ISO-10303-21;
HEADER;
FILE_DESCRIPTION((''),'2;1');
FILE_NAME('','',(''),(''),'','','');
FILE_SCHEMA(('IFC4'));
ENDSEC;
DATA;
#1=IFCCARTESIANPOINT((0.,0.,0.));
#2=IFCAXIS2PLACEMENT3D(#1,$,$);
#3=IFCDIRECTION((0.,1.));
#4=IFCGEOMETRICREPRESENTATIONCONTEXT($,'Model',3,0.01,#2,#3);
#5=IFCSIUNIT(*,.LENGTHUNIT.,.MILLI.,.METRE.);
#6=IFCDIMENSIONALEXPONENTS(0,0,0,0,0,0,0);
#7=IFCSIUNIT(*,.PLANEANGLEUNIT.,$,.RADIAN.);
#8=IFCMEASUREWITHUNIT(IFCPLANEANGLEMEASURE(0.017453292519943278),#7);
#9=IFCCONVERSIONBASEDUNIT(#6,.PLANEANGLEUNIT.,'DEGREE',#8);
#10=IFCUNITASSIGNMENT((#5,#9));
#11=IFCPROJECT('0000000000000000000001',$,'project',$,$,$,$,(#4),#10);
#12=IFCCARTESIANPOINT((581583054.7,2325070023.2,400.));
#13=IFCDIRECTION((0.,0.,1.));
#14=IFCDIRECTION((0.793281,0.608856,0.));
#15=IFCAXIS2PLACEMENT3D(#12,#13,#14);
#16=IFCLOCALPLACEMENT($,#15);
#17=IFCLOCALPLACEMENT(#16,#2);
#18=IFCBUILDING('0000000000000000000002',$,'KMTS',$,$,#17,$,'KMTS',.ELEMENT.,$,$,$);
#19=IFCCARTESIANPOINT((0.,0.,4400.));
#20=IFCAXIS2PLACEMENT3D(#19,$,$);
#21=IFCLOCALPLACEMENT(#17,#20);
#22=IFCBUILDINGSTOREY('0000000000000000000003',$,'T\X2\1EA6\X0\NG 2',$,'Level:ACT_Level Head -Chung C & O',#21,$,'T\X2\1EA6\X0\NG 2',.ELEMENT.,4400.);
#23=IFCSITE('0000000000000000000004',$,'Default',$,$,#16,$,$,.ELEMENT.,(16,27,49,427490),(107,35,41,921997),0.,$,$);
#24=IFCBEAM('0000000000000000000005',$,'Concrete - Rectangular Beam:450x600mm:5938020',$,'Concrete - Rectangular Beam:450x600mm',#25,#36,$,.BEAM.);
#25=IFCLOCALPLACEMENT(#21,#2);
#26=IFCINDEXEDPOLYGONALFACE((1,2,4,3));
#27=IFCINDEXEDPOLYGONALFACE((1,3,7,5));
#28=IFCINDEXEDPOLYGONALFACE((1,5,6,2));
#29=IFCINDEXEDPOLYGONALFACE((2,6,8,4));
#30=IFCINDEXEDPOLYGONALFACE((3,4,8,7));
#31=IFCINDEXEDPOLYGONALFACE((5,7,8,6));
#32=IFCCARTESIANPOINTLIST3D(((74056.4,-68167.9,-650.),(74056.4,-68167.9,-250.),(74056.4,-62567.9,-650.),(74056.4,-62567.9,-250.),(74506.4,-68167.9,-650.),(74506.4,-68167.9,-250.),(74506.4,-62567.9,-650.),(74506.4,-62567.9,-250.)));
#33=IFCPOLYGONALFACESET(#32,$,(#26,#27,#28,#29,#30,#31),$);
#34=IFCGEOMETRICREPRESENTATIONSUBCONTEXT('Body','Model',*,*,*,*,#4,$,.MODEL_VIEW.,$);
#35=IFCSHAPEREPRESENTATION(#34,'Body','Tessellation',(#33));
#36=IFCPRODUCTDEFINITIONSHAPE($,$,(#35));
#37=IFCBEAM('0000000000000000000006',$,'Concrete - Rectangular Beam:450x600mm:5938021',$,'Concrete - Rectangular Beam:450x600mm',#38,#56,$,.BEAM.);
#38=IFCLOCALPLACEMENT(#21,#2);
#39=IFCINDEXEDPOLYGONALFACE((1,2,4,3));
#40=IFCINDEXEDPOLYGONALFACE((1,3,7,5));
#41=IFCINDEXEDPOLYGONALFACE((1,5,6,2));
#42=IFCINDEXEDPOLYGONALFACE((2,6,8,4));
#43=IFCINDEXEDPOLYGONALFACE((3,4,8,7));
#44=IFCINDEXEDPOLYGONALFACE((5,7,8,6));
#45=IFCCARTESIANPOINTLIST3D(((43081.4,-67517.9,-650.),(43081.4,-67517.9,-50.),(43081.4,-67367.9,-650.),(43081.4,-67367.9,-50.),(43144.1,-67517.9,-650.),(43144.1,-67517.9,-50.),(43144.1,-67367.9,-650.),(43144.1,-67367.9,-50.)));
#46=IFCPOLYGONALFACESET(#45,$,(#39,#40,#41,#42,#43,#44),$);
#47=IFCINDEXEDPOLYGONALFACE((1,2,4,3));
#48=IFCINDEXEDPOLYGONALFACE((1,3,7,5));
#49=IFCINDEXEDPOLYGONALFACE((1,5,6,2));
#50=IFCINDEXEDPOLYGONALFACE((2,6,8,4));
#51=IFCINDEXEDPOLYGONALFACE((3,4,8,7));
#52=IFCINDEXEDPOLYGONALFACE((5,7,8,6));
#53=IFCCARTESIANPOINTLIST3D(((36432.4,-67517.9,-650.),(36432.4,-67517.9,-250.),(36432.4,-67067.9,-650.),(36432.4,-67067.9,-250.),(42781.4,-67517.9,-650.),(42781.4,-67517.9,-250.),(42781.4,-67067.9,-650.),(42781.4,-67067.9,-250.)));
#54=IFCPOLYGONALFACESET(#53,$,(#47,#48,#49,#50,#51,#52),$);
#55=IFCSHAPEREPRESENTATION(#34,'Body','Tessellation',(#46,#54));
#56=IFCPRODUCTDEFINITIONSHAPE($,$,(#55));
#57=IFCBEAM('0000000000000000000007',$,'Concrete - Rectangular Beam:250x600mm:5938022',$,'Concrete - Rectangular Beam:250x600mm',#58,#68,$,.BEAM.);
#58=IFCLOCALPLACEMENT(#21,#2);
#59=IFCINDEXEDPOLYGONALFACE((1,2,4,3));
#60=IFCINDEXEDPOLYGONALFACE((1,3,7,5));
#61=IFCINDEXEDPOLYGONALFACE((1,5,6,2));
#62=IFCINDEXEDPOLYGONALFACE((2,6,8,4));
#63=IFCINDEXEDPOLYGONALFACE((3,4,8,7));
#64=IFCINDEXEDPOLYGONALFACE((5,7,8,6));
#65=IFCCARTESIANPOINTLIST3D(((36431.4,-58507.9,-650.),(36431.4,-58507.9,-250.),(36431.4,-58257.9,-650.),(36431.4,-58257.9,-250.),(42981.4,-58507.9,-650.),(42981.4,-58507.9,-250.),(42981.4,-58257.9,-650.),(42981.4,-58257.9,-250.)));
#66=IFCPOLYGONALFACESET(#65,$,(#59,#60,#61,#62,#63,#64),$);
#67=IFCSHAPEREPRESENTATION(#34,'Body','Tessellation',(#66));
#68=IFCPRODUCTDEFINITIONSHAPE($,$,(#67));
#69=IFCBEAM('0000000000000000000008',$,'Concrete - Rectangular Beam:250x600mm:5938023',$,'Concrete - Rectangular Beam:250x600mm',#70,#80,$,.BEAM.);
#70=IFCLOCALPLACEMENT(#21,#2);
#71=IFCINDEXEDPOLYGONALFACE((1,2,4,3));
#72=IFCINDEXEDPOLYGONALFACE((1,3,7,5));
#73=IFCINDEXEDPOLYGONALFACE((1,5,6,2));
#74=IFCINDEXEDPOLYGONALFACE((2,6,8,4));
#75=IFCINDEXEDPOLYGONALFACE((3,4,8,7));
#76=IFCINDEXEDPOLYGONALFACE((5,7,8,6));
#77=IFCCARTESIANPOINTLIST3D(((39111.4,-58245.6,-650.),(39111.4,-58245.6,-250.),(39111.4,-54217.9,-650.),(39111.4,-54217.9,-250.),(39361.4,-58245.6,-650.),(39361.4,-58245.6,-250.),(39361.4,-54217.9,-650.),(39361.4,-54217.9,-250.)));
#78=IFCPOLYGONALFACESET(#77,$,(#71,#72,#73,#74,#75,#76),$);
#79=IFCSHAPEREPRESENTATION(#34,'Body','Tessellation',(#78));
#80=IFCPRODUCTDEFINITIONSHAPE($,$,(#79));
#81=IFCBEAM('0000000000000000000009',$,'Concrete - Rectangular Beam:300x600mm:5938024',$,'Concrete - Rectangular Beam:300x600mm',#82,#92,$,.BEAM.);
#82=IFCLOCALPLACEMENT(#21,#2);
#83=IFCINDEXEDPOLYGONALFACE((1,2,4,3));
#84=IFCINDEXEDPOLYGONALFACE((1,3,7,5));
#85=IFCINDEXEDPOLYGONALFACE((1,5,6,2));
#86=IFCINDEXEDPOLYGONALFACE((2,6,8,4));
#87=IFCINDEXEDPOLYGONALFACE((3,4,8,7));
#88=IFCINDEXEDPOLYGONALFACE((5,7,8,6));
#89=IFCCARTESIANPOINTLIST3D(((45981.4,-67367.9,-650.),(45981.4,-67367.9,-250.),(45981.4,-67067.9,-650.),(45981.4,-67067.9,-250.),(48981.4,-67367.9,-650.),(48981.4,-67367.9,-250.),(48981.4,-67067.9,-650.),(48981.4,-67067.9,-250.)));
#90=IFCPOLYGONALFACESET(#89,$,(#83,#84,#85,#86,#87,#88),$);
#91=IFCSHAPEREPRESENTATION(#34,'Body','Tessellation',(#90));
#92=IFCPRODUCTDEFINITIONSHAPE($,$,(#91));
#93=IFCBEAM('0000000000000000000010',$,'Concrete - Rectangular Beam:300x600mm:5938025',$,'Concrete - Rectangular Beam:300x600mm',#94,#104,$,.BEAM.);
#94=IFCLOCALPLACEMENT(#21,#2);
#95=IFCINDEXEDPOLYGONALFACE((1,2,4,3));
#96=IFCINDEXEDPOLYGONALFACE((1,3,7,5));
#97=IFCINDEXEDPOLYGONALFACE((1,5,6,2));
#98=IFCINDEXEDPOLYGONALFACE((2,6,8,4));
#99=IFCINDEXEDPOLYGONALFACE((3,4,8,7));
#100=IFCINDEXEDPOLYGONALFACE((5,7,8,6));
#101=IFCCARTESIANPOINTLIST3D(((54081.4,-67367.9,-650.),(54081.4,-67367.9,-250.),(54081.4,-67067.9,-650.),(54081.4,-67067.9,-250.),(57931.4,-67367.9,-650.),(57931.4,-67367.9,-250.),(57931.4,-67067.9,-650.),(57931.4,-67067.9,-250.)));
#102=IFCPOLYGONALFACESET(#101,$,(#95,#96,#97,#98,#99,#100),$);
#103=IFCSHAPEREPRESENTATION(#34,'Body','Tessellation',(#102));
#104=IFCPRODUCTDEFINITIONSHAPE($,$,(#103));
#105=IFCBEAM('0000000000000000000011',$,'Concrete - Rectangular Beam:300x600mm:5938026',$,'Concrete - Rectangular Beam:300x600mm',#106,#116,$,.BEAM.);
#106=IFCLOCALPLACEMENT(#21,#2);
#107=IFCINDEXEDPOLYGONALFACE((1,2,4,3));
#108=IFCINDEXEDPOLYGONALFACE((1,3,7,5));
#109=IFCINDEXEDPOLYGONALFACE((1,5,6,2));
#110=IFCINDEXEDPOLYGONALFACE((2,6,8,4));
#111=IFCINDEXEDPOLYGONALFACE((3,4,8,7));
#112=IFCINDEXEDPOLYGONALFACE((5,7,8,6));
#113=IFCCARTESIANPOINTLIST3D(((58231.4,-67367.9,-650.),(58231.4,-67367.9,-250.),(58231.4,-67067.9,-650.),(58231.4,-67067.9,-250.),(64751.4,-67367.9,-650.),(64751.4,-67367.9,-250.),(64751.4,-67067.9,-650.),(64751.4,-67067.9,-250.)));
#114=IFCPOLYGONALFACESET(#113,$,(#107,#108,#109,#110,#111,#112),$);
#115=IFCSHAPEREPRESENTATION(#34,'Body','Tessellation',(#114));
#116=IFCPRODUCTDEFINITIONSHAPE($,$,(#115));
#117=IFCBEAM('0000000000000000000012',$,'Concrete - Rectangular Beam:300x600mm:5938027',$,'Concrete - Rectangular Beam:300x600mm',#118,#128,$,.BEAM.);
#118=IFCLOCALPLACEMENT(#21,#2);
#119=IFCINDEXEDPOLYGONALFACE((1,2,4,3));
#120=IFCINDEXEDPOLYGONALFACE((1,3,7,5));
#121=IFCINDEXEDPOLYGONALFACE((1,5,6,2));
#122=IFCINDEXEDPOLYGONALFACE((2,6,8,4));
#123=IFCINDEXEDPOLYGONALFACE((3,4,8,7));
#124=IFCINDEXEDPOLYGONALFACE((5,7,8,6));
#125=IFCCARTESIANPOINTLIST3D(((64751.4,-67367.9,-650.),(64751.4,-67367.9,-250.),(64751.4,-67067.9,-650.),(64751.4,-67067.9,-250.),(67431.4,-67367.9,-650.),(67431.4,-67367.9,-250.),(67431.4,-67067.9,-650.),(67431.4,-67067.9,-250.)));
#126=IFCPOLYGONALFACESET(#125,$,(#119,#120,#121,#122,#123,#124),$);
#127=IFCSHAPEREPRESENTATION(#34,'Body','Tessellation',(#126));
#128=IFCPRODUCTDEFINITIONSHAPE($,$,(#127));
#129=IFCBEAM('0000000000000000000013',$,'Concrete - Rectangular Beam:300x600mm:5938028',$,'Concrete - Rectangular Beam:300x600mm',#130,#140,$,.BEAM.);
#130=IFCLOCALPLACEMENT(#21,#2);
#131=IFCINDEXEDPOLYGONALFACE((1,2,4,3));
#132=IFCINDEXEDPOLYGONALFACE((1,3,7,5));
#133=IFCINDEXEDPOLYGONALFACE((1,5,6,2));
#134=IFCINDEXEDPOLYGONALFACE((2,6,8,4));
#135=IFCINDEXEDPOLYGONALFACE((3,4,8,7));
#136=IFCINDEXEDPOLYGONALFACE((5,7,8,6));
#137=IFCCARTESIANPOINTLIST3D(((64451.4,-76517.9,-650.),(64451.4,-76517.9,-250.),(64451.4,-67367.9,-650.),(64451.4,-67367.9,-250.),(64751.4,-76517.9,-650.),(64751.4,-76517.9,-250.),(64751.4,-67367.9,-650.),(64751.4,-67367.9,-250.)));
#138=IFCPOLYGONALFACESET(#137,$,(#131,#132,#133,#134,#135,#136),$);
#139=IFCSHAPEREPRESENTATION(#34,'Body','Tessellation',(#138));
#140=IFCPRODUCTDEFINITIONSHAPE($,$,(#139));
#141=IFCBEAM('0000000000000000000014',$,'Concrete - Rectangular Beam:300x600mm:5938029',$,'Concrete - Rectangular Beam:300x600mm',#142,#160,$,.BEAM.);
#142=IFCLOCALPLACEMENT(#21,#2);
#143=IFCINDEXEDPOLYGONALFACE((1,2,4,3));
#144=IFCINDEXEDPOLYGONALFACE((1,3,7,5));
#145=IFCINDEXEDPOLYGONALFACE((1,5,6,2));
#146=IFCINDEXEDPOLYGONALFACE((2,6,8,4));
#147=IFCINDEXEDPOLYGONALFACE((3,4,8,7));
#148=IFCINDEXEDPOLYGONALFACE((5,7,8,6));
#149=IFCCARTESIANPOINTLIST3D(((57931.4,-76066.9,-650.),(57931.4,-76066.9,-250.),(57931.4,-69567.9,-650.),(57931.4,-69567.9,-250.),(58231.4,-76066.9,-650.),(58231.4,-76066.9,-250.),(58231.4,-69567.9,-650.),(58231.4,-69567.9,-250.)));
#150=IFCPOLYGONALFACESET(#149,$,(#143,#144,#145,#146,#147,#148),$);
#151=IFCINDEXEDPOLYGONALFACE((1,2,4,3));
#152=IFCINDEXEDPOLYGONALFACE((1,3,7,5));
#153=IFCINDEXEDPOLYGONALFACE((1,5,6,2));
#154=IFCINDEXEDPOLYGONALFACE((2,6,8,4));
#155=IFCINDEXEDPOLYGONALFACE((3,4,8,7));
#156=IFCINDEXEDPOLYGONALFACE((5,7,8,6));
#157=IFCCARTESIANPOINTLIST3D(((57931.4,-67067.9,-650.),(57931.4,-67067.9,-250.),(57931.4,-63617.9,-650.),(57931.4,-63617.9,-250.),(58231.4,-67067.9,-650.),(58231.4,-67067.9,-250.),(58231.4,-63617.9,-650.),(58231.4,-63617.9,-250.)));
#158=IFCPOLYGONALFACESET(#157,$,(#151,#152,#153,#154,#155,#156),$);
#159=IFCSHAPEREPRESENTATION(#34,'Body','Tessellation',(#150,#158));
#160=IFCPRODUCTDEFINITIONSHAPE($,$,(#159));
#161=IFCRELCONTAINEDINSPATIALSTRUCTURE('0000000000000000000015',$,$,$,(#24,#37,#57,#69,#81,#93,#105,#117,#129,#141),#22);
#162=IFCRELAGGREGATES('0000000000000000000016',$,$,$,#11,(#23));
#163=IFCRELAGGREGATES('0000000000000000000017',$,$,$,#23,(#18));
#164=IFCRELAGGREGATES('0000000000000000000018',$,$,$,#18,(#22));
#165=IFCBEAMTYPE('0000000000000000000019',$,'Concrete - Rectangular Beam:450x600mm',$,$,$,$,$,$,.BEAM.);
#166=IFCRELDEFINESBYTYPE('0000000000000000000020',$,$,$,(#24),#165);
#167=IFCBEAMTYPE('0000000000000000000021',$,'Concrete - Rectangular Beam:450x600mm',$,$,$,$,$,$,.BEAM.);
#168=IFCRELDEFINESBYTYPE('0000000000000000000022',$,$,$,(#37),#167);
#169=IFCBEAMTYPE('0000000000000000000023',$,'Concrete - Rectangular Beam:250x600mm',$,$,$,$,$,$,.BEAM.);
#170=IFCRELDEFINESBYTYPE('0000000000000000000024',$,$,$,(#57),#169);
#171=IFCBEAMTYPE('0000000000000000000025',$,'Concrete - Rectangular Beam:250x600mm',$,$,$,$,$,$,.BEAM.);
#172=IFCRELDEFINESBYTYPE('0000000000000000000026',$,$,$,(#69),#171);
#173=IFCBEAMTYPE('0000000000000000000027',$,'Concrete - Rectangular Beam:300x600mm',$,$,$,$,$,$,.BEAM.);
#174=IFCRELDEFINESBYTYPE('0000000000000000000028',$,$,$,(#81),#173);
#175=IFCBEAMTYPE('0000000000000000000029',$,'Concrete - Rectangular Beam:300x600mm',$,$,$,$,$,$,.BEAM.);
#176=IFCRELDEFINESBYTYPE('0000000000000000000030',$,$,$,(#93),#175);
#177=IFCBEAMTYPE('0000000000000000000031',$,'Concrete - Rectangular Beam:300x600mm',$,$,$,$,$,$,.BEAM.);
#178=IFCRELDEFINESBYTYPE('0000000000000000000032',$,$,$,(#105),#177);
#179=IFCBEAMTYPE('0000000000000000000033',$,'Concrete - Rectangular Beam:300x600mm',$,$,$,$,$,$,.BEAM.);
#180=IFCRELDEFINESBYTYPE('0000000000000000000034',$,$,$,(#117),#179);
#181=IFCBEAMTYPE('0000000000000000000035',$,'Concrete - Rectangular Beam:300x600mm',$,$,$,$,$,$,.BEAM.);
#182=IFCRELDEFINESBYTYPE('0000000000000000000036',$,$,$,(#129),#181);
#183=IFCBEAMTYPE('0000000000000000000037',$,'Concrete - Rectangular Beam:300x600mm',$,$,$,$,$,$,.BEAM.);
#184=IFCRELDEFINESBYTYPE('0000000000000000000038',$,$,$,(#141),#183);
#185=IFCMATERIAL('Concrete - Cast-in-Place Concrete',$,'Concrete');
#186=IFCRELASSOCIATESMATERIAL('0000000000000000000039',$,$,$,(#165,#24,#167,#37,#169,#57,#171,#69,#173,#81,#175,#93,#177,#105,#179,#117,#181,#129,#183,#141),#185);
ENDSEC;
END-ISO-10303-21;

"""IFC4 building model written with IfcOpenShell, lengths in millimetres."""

from ifc_helpers import new_model, entity, si_unit, converted_unit, direction, frame, origin, place, context, subcontext, project, spatial, indexed_curve, outline, extrude, source, transform, mapped, material, type_object, type_shapes, element, save


model = new_model("IFC4")

# Units and contexts
model_context = context("Model", 3, precision=0.01, world=origin(), true_north=direction((0.0, 1.0)))
body_context = subcontext(model_context, "Body", "Model", "MODEL_VIEW")
ifc_project = project(units=[si_unit("LENGTHUNIT", "METRE", prefix="MILLI"), converted_unit("PLANEANGLEUNIT", "DEGREE", entity("IfcPlaneAngleMeasure", 0.017453292519943278), si_unit("PLANEANGLEUNIT", "RADIAN"), dimensions=[0, 0, 0, 0, 0, 0, 0])], contexts=[model_context])

# Site, building, storey
site_placement = place(None, frame((581583054.7, 2325070023.2, 400.0), z_axis=(0.0, 0.0, 1.0), x_axis=(0.793281, 0.608856, 0.0)))
site = spatial("IfcSite", under=ifc_project, at=site_placement, Name="Default", CompositionType="ELEMENT", RefLatitude=(16, 27, 49, 427490), RefLongitude=(107, 35, 41, 921997), RefElevation=0.0)
building_placement = place(site_placement, origin())
building = spatial("IfcBuilding", under=site, at=building_placement, Name="KMTS", LongName="KMTS", CompositionType="ELEMENT")
storey_placement = place(building_placement, frame((0.0, 0.0, 4400.0)))
storey = spatial("IfcBuildingStorey", under=building, at=storey_placement, Name="TẦNG 2", ObjectType="Level:ACT_Level Head -Chung C & O", LongName="TẦNG 2", CompositionType="ELEMENT", Elevation=4400.0)

# Beams
ifc_material_1 = material(Name="Concrete - Cast-in-Place Concrete", Category="Concrete")
beam_type_1 = type_object("IfcBeamType", Name="Concrete - Rectangular Beam:450x600mm", PredefinedType="BEAM", material=ifc_material_1)
shared_shape_1 = source(origin(), body_context, "Body", "SweptSolid", [
    extrude(outline(indexed_curve([(-225.0, -200.0), (225.0, -200.0), (225.0, 200.0), (-225.0, 200.0), (-225.0, -200.0)], self_intersect=False)), frame((74281.4, -68167.9, 3950.0), z_axis=(0.0, 1.0, 0.0), x_axis=(-1.0, 0.0, 0.0)), (0.0, 0.0, 1.0), 5600.0),
])
type_shapes(beam_type_1, [shared_shape_1])
beam_1_placement = place(storey_placement, frame((0.0, 0.0, -4400.0)))
element("IfcBeam", 1, at=beam_1_placement, inside=storey, type_object=beam_type_1, material=ifc_material_1, Name="Concrete - Rectangular Beam:450x600mm:5938020", ObjectType="Concrete - Rectangular Beam:450x600mm", PredefinedType="BEAM", context=body_context, shape_type="MappedRepresentation", body=[
    mapped(shared_shape_1, transform((0.0, 0.0, 0.0), scale=1.0)),
])
beam_type_2 = type_object("IfcBeamType", Name="Concrete - Rectangular Beam:450x600mm", PredefinedType="BEAM", material=ifc_material_1)
shared_shape_2 = source(origin(), body_context, "Body", "SweptSolid", [
    extrude(outline(indexed_curve([(-300.0, -75.0), (300.0, -75.0), (300.0, 75.0), (-300.0, 75.0), (-300.0, -75.0)], self_intersect=False)), frame((43081.4, -67442.9, 4050.0), z_axis=(1.0, 0.0, 0.0), x_axis=(0.0, 0.0, -1.0)), (0.0, 0.0, 1.0), 62.7),
    extrude(outline(indexed_curve([(-200.0, -225.0), (200.0, -225.0), (200.0, 225.0), (-200.0, 225.0), (-200.0, -225.0)], self_intersect=False)), frame((36432.4, -67292.9, 3950.0), z_axis=(1.0, 0.0, 0.0), x_axis=(0.0, 0.0, -1.0)), (0.0, 0.0, 1.0), 6349.0),
])
type_shapes(beam_type_2, [shared_shape_2])
beam_2_placement = place(storey_placement, frame((0.0, 0.0, -4400.0)))
element("IfcBeam", 2, at=beam_2_placement, inside=storey, type_object=beam_type_2, material=ifc_material_1, Name="Concrete - Rectangular Beam:450x600mm:5938021", ObjectType="Concrete - Rectangular Beam:450x600mm", PredefinedType="BEAM", context=body_context, shape_type="MappedRepresentation", body=[
    mapped(shared_shape_2, transform((0.0, 0.0, 0.0), scale=1.0)),
])
beam_type_3 = type_object("IfcBeamType", Name="Concrete - Rectangular Beam:250x600mm", PredefinedType="BEAM", material=ifc_material_1)
shared_shape_3 = source(origin(), body_context, "Body", "SweptSolid", [
    extrude(outline(indexed_curve([(-200.0, -125.0), (200.0, -125.0), (200.0, 125.0), (-200.0, 125.0), (-200.0, -125.0)], self_intersect=False)), frame((42981.4, -58382.9, 3950.0), z_axis=(-1.0, 0.0, 0.0), x_axis=(0.0, 0.0, -1.0)), (0.0, 0.0, 1.0), 6550.0),
])
type_shapes(beam_type_3, [shared_shape_3])
beam_3_placement = place(storey_placement, frame((0.0, 0.0, -4400.0)))
element("IfcBeam", 3, at=beam_3_placement, inside=storey, type_object=beam_type_3, material=ifc_material_1, Name="Concrete - Rectangular Beam:250x600mm:5938022", ObjectType="Concrete - Rectangular Beam:250x600mm", PredefinedType="BEAM", context=body_context, shape_type="MappedRepresentation", body=[
    mapped(shared_shape_3, transform((0.0, 0.0, 0.0), scale=1.0)),
])
beam_type_4 = type_object("IfcBeamType", Name="Concrete - Rectangular Beam:250x600mm", PredefinedType="BEAM", material=ifc_material_1)
shared_shape_4 = source(origin(), body_context, "Body", "SweptSolid", [
    extrude(outline(indexed_curve([(-125.0, -200.0), (125.0, -200.0), (125.0, 200.0), (-125.0, 200.0), (-125.0, -200.0)], self_intersect=False)), frame((39236.4, -54217.9, 3950.0), z_axis=(0.0, -1.0, 0.0), x_axis=(-1.0, 0.0, 0.0)), (0.0, 0.0, 1.0), 4027.7),
])
type_shapes(beam_type_4, [shared_shape_4])
beam_4_placement = place(storey_placement, frame((0.0, 0.0, -4400.0)))
element("IfcBeam", 4, at=beam_4_placement, inside=storey, type_object=beam_type_4, material=ifc_material_1, Name="Concrete - Rectangular Beam:250x600mm:5938023", ObjectType="Concrete - Rectangular Beam:250x600mm", PredefinedType="BEAM", context=body_context, shape_type="MappedRepresentation", body=[
    mapped(shared_shape_4, transform((0.0, 0.0, 0.0), scale=1.0)),
])
beam_type_5 = type_object("IfcBeamType", Name="Concrete - Rectangular Beam:300x600mm", PredefinedType="BEAM", material=ifc_material_1)
shared_shape_5 = source(origin(), body_context, "Body", "SweptSolid", [
    extrude(outline(indexed_curve([(-200.0, -150.0), (200.0, -150.0), (200.0, 150.0), (-200.0, 150.0), (-200.0, -150.0)], self_intersect=False)), frame((48981.4, -67217.9, 3950.0), z_axis=(-1.0, 0.0, 0.0), x_axis=(0.0, 0.0, -1.0)), (0.0, 0.0, 1.0), 3000.0),
])
type_shapes(beam_type_5, [shared_shape_5])
beam_5_placement = place(storey_placement, frame((0.0, 0.0, -4400.0)))
element("IfcBeam", 5, at=beam_5_placement, inside=storey, type_object=beam_type_5, material=ifc_material_1, Name="Concrete - Rectangular Beam:300x600mm:5938024", ObjectType="Concrete - Rectangular Beam:300x600mm", PredefinedType="BEAM", context=body_context, shape_type="MappedRepresentation", body=[
    mapped(shared_shape_5, transform((0.0, 0.0, 0.0), scale=1.0)),
])
beam_type_6 = type_object("IfcBeamType", Name="Concrete - Rectangular Beam:300x600mm", PredefinedType="BEAM", material=ifc_material_1)
shared_shape_6 = source(origin(), body_context, "Body", "SweptSolid", [
    extrude(outline(indexed_curve([(-200.0, -150.0), (200.0, -150.0), (200.0, 150.0), (-200.0, 150.0), (-200.0, -150.0)], self_intersect=False)), frame((54081.4, -67217.9, 3950.0), z_axis=(1.0, 0.0, 0.0), x_axis=(0.0, 0.0, -1.0)), (0.0, 0.0, 1.0), 3850.0),
])
type_shapes(beam_type_6, [shared_shape_6])
beam_6_placement = place(storey_placement, frame((0.0, 0.0, -4400.0)))
element("IfcBeam", 6, at=beam_6_placement, inside=storey, type_object=beam_type_6, material=ifc_material_1, Name="Concrete - Rectangular Beam:300x600mm:5938025", ObjectType="Concrete - Rectangular Beam:300x600mm", PredefinedType="BEAM", context=body_context, shape_type="MappedRepresentation", body=[
    mapped(shared_shape_6, transform((0.0, 0.0, 0.0), scale=1.0)),
])
beam_type_7 = type_object("IfcBeamType", Name="Concrete - Rectangular Beam:300x600mm", PredefinedType="BEAM", material=ifc_material_1)
shared_shape_7 = source(origin(), body_context, "Body", "SweptSolid", [
    extrude(outline(indexed_curve([(-200.0, -150.0), (200.0, -150.0), (200.0, 150.0), (-200.0, 150.0), (-200.0, -150.0)], self_intersect=False)), frame((58231.4, -67217.9, 3950.0), z_axis=(1.0, 0.0, 0.0), x_axis=(0.0, 0.0, -1.0)), (0.0, 0.0, 1.0), 6520.0),
])
type_shapes(beam_type_7, [shared_shape_7])
beam_7_placement = place(storey_placement, frame((0.0, 0.0, -4400.0)))
element("IfcBeam", 7, at=beam_7_placement, inside=storey, type_object=beam_type_7, material=ifc_material_1, Name="Concrete - Rectangular Beam:300x600mm:5938026", ObjectType="Concrete - Rectangular Beam:300x600mm", PredefinedType="BEAM", context=body_context, shape_type="MappedRepresentation", body=[
    mapped(shared_shape_7, transform((0.0, 0.0, 0.0), scale=1.0)),
])
beam_type_8 = type_object("IfcBeamType", Name="Concrete - Rectangular Beam:300x600mm", PredefinedType="BEAM", material=ifc_material_1)
shared_shape_8 = source(origin(), body_context, "Body", "SweptSolid", [
    extrude(outline(indexed_curve([(-200.0, -150.0), (200.0, -150.0), (200.0, 150.0), (-200.0, 150.0), (-200.0, -150.0)], self_intersect=False)), frame((67431.4, -67217.9, 3950.0), z_axis=(-1.0, 0.0, 0.0), x_axis=(0.0, 0.0, -1.0)), (0.0, 0.0, 1.0), 2680.0),
])
type_shapes(beam_type_8, [shared_shape_8])
beam_8_placement = place(storey_placement, frame((0.0, 0.0, -4400.0)))
element("IfcBeam", 8, at=beam_8_placement, inside=storey, type_object=beam_type_8, material=ifc_material_1, Name="Concrete - Rectangular Beam:300x600mm:5938027", ObjectType="Concrete - Rectangular Beam:300x600mm", PredefinedType="BEAM", context=body_context, shape_type="MappedRepresentation", body=[
    mapped(shared_shape_8, transform((0.0, 0.0, 0.0), scale=1.0)),
])
beam_type_9 = type_object("IfcBeamType", Name="Concrete - Rectangular Beam:300x600mm", PredefinedType="BEAM", material=ifc_material_1)
shared_shape_9 = source(origin(), body_context, "Body", "SweptSolid", [
    extrude(outline(indexed_curve([(-150.0, -200.0), (150.0, -200.0), (150.0, 200.0), (-150.0, 200.0), (-150.0, -200.0)], self_intersect=False)), frame((64601.4, -67367.9, 3950.0), z_axis=(0.0, -1.0, 0.0), x_axis=(-1.0, 0.0, 0.0)), (0.0, 0.0, 1.0), 9150.0),
])
type_shapes(beam_type_9, [shared_shape_9])
beam_9_placement = place(storey_placement, frame((0.0, 0.0, -4400.0)))
element("IfcBeam", 9, at=beam_9_placement, inside=storey, type_object=beam_type_9, material=ifc_material_1, Name="Concrete - Rectangular Beam:300x600mm:5938028", ObjectType="Concrete - Rectangular Beam:300x600mm", PredefinedType="BEAM", context=body_context, shape_type="MappedRepresentation", body=[
    mapped(shared_shape_9, transform((0.0, 0.0, 0.0), scale=1.0)),
])
beam_type_10 = type_object("IfcBeamType", Name="Concrete - Rectangular Beam:300x600mm", PredefinedType="BEAM", material=ifc_material_1)
shared_shape_10 = source(origin(), body_context, "Body", "SweptSolid", [
    extrude(outline(indexed_curve([(-150.0, -200.0), (150.0, -200.0), (150.0, 200.0), (-150.0, 200.0), (-150.0, -200.0)], self_intersect=False)), frame((58081.4, -69567.9, 3950.0), z_axis=(0.0, -1.0, 0.0), x_axis=(-1.0, 0.0, 0.0)), (0.0, 0.0, 1.0), 6499.0),
    extrude(outline(indexed_curve([(-150.0, -200.0), (150.0, -200.0), (150.0, 200.0), (-150.0, 200.0), (-150.0, -200.0)], self_intersect=False)), frame((58081.4, -63617.9, 3950.0), z_axis=(0.0, -1.0, 0.0), x_axis=(-1.0, 0.0, 0.0)), (0.0, 0.0, 1.0), 3450.0),
])
type_shapes(beam_type_10, [shared_shape_10])
beam_10_placement = place(storey_placement, frame((0.0, 0.0, -4400.0)))
element("IfcBeam", 10, at=beam_10_placement, inside=storey, type_object=beam_type_10, material=ifc_material_1, Name="Concrete - Rectangular Beam:300x600mm:5938029", ObjectType="Concrete - Rectangular Beam:300x600mm", PredefinedType="BEAM", context=body_context, shape_type="MappedRepresentation", body=[
    mapped(shared_shape_10, transform((0.0, 0.0, 0.0), scale=1.0)),
])

save(model, "model.ifc")
